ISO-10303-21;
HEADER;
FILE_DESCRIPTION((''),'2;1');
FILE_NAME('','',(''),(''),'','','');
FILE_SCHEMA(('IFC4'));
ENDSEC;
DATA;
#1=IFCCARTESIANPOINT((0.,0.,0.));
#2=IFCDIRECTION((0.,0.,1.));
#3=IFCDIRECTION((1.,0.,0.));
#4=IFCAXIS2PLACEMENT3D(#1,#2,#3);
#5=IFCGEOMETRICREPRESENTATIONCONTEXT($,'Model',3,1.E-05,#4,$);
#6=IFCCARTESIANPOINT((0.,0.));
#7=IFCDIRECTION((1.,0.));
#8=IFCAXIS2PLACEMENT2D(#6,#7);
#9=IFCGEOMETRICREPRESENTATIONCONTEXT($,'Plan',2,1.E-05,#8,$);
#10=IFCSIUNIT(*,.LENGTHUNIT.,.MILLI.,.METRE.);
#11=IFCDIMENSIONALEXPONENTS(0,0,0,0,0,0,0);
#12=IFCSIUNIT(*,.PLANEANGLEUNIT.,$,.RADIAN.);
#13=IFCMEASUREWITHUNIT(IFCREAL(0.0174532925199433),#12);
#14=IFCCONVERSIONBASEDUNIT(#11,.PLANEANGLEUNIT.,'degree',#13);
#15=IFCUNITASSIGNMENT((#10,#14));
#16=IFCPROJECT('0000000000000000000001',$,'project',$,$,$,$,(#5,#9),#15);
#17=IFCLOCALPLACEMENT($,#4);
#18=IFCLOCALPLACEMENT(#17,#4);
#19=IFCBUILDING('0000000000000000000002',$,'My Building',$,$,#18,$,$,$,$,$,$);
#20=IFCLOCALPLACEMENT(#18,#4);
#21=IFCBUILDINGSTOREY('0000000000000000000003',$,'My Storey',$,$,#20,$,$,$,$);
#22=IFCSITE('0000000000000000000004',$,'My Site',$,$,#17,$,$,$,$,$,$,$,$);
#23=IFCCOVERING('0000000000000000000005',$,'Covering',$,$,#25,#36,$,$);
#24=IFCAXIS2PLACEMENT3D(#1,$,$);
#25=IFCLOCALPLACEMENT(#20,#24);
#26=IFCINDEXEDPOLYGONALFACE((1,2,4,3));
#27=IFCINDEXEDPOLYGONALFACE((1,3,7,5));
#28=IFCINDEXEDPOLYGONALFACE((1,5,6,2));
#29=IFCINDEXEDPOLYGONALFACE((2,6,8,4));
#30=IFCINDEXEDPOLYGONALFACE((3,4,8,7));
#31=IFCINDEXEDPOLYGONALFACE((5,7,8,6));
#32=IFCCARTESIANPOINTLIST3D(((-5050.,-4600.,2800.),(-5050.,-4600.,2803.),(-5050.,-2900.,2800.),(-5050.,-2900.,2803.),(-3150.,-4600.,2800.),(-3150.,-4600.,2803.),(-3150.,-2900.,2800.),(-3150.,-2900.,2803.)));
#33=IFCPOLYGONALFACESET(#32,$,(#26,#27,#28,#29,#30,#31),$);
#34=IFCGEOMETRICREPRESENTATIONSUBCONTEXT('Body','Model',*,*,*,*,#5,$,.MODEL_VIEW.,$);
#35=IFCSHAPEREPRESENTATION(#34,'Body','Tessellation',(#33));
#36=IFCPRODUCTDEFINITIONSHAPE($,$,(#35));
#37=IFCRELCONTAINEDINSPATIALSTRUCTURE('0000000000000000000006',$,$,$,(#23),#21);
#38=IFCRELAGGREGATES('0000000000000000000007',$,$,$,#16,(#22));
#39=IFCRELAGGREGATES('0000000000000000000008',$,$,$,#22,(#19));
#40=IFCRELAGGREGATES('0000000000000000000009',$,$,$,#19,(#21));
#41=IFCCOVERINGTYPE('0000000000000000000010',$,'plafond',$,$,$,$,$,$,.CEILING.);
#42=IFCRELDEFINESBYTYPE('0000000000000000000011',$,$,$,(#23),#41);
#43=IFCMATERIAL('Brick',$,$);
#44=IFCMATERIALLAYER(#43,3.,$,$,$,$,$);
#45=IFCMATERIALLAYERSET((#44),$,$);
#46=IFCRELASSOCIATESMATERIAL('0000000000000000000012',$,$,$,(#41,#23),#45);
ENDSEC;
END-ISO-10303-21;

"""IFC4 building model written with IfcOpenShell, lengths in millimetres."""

from ifc_helpers import new_model, entity, si_unit, converted_unit, frame, origin_with_axes, origin_2d_with_axis, place, context, subcontext, project, spatial, line, indexed_curve, outline, extrude, material, layer, layer_set, layer_usage, type_object, element, save


model = new_model("IFC4")

# Units and contexts
model_context = context("Model", 3, precision=1e-05, world=origin_with_axes())
plan_context = context("Plan", 2, precision=1e-05, world=origin_2d_with_axis())
body_context_1 = subcontext(model_context, "Body", "Model", "MODEL_VIEW")
ifc_project = project(units=[si_unit("LENGTHUNIT", "METRE", prefix="MILLI"), converted_unit("PLANEANGLEUNIT", "degree", entity("IfcReal", 0.0174532925199433), si_unit("PLANEANGLEUNIT", "RADIAN"), dimensions=[0, 0, 0, 0, 0, 0, 0])], contexts=[model_context, plan_context])

# Site, building, storey
site_placement = place(None, origin_with_axes())
site = spatial("IfcSite", under=ifc_project, at=site_placement, Name="My Site")
building_placement = place(site_placement, origin_with_axes())
building = spatial("IfcBuilding", under=site, at=building_placement, Name="My Building")
storey_placement = place(building_placement, origin_with_axes())
storey = spatial("IfcBuildingStorey", under=building, at=storey_placement, Name="My Storey")

# Shared definitions
ifc_material = material(Name="Brick")

# Covering
ifc_layer_1 = layer(ifc_material, 3.0)
ifc_layer_set_1 = layer_set([ifc_layer_1])
covering_type = type_object("IfcCoveringType", Name="plafond", PredefinedType="CEILING", material=ifc_layer_set_1)
ifc_layer_usage_1 = layer_usage(ifc_layer_set_1, "AXIS3", "POSITIVE", 0.0)
covering_1_placement = place(storey_placement, frame((-5050.0, -4600.0, 2800.0), z_axis=(0.0, 0.0, 1.0), x_axis=(1.0, 0.0, 0.0)))
element("IfcCovering", 1, at=covering_1_placement, inside=storey, type_object=covering_type, material=ifc_layer_usage_1, Name="Covering", context=body_context_1, shape_type="SweptSolid", body=[
    extrude(outline(indexed_curve([(0.0, 0.0), (1900.0, 0.0), (1900.0, 1700.0), (0.0, 1700.0)], segments=[line(4, 1), line(1, 2), line(2, 3), line(3, 4)], self_intersect=False)), None, (0.0, 0.0, 1.0), 3.0),
])

save(model, "model.ifc")
